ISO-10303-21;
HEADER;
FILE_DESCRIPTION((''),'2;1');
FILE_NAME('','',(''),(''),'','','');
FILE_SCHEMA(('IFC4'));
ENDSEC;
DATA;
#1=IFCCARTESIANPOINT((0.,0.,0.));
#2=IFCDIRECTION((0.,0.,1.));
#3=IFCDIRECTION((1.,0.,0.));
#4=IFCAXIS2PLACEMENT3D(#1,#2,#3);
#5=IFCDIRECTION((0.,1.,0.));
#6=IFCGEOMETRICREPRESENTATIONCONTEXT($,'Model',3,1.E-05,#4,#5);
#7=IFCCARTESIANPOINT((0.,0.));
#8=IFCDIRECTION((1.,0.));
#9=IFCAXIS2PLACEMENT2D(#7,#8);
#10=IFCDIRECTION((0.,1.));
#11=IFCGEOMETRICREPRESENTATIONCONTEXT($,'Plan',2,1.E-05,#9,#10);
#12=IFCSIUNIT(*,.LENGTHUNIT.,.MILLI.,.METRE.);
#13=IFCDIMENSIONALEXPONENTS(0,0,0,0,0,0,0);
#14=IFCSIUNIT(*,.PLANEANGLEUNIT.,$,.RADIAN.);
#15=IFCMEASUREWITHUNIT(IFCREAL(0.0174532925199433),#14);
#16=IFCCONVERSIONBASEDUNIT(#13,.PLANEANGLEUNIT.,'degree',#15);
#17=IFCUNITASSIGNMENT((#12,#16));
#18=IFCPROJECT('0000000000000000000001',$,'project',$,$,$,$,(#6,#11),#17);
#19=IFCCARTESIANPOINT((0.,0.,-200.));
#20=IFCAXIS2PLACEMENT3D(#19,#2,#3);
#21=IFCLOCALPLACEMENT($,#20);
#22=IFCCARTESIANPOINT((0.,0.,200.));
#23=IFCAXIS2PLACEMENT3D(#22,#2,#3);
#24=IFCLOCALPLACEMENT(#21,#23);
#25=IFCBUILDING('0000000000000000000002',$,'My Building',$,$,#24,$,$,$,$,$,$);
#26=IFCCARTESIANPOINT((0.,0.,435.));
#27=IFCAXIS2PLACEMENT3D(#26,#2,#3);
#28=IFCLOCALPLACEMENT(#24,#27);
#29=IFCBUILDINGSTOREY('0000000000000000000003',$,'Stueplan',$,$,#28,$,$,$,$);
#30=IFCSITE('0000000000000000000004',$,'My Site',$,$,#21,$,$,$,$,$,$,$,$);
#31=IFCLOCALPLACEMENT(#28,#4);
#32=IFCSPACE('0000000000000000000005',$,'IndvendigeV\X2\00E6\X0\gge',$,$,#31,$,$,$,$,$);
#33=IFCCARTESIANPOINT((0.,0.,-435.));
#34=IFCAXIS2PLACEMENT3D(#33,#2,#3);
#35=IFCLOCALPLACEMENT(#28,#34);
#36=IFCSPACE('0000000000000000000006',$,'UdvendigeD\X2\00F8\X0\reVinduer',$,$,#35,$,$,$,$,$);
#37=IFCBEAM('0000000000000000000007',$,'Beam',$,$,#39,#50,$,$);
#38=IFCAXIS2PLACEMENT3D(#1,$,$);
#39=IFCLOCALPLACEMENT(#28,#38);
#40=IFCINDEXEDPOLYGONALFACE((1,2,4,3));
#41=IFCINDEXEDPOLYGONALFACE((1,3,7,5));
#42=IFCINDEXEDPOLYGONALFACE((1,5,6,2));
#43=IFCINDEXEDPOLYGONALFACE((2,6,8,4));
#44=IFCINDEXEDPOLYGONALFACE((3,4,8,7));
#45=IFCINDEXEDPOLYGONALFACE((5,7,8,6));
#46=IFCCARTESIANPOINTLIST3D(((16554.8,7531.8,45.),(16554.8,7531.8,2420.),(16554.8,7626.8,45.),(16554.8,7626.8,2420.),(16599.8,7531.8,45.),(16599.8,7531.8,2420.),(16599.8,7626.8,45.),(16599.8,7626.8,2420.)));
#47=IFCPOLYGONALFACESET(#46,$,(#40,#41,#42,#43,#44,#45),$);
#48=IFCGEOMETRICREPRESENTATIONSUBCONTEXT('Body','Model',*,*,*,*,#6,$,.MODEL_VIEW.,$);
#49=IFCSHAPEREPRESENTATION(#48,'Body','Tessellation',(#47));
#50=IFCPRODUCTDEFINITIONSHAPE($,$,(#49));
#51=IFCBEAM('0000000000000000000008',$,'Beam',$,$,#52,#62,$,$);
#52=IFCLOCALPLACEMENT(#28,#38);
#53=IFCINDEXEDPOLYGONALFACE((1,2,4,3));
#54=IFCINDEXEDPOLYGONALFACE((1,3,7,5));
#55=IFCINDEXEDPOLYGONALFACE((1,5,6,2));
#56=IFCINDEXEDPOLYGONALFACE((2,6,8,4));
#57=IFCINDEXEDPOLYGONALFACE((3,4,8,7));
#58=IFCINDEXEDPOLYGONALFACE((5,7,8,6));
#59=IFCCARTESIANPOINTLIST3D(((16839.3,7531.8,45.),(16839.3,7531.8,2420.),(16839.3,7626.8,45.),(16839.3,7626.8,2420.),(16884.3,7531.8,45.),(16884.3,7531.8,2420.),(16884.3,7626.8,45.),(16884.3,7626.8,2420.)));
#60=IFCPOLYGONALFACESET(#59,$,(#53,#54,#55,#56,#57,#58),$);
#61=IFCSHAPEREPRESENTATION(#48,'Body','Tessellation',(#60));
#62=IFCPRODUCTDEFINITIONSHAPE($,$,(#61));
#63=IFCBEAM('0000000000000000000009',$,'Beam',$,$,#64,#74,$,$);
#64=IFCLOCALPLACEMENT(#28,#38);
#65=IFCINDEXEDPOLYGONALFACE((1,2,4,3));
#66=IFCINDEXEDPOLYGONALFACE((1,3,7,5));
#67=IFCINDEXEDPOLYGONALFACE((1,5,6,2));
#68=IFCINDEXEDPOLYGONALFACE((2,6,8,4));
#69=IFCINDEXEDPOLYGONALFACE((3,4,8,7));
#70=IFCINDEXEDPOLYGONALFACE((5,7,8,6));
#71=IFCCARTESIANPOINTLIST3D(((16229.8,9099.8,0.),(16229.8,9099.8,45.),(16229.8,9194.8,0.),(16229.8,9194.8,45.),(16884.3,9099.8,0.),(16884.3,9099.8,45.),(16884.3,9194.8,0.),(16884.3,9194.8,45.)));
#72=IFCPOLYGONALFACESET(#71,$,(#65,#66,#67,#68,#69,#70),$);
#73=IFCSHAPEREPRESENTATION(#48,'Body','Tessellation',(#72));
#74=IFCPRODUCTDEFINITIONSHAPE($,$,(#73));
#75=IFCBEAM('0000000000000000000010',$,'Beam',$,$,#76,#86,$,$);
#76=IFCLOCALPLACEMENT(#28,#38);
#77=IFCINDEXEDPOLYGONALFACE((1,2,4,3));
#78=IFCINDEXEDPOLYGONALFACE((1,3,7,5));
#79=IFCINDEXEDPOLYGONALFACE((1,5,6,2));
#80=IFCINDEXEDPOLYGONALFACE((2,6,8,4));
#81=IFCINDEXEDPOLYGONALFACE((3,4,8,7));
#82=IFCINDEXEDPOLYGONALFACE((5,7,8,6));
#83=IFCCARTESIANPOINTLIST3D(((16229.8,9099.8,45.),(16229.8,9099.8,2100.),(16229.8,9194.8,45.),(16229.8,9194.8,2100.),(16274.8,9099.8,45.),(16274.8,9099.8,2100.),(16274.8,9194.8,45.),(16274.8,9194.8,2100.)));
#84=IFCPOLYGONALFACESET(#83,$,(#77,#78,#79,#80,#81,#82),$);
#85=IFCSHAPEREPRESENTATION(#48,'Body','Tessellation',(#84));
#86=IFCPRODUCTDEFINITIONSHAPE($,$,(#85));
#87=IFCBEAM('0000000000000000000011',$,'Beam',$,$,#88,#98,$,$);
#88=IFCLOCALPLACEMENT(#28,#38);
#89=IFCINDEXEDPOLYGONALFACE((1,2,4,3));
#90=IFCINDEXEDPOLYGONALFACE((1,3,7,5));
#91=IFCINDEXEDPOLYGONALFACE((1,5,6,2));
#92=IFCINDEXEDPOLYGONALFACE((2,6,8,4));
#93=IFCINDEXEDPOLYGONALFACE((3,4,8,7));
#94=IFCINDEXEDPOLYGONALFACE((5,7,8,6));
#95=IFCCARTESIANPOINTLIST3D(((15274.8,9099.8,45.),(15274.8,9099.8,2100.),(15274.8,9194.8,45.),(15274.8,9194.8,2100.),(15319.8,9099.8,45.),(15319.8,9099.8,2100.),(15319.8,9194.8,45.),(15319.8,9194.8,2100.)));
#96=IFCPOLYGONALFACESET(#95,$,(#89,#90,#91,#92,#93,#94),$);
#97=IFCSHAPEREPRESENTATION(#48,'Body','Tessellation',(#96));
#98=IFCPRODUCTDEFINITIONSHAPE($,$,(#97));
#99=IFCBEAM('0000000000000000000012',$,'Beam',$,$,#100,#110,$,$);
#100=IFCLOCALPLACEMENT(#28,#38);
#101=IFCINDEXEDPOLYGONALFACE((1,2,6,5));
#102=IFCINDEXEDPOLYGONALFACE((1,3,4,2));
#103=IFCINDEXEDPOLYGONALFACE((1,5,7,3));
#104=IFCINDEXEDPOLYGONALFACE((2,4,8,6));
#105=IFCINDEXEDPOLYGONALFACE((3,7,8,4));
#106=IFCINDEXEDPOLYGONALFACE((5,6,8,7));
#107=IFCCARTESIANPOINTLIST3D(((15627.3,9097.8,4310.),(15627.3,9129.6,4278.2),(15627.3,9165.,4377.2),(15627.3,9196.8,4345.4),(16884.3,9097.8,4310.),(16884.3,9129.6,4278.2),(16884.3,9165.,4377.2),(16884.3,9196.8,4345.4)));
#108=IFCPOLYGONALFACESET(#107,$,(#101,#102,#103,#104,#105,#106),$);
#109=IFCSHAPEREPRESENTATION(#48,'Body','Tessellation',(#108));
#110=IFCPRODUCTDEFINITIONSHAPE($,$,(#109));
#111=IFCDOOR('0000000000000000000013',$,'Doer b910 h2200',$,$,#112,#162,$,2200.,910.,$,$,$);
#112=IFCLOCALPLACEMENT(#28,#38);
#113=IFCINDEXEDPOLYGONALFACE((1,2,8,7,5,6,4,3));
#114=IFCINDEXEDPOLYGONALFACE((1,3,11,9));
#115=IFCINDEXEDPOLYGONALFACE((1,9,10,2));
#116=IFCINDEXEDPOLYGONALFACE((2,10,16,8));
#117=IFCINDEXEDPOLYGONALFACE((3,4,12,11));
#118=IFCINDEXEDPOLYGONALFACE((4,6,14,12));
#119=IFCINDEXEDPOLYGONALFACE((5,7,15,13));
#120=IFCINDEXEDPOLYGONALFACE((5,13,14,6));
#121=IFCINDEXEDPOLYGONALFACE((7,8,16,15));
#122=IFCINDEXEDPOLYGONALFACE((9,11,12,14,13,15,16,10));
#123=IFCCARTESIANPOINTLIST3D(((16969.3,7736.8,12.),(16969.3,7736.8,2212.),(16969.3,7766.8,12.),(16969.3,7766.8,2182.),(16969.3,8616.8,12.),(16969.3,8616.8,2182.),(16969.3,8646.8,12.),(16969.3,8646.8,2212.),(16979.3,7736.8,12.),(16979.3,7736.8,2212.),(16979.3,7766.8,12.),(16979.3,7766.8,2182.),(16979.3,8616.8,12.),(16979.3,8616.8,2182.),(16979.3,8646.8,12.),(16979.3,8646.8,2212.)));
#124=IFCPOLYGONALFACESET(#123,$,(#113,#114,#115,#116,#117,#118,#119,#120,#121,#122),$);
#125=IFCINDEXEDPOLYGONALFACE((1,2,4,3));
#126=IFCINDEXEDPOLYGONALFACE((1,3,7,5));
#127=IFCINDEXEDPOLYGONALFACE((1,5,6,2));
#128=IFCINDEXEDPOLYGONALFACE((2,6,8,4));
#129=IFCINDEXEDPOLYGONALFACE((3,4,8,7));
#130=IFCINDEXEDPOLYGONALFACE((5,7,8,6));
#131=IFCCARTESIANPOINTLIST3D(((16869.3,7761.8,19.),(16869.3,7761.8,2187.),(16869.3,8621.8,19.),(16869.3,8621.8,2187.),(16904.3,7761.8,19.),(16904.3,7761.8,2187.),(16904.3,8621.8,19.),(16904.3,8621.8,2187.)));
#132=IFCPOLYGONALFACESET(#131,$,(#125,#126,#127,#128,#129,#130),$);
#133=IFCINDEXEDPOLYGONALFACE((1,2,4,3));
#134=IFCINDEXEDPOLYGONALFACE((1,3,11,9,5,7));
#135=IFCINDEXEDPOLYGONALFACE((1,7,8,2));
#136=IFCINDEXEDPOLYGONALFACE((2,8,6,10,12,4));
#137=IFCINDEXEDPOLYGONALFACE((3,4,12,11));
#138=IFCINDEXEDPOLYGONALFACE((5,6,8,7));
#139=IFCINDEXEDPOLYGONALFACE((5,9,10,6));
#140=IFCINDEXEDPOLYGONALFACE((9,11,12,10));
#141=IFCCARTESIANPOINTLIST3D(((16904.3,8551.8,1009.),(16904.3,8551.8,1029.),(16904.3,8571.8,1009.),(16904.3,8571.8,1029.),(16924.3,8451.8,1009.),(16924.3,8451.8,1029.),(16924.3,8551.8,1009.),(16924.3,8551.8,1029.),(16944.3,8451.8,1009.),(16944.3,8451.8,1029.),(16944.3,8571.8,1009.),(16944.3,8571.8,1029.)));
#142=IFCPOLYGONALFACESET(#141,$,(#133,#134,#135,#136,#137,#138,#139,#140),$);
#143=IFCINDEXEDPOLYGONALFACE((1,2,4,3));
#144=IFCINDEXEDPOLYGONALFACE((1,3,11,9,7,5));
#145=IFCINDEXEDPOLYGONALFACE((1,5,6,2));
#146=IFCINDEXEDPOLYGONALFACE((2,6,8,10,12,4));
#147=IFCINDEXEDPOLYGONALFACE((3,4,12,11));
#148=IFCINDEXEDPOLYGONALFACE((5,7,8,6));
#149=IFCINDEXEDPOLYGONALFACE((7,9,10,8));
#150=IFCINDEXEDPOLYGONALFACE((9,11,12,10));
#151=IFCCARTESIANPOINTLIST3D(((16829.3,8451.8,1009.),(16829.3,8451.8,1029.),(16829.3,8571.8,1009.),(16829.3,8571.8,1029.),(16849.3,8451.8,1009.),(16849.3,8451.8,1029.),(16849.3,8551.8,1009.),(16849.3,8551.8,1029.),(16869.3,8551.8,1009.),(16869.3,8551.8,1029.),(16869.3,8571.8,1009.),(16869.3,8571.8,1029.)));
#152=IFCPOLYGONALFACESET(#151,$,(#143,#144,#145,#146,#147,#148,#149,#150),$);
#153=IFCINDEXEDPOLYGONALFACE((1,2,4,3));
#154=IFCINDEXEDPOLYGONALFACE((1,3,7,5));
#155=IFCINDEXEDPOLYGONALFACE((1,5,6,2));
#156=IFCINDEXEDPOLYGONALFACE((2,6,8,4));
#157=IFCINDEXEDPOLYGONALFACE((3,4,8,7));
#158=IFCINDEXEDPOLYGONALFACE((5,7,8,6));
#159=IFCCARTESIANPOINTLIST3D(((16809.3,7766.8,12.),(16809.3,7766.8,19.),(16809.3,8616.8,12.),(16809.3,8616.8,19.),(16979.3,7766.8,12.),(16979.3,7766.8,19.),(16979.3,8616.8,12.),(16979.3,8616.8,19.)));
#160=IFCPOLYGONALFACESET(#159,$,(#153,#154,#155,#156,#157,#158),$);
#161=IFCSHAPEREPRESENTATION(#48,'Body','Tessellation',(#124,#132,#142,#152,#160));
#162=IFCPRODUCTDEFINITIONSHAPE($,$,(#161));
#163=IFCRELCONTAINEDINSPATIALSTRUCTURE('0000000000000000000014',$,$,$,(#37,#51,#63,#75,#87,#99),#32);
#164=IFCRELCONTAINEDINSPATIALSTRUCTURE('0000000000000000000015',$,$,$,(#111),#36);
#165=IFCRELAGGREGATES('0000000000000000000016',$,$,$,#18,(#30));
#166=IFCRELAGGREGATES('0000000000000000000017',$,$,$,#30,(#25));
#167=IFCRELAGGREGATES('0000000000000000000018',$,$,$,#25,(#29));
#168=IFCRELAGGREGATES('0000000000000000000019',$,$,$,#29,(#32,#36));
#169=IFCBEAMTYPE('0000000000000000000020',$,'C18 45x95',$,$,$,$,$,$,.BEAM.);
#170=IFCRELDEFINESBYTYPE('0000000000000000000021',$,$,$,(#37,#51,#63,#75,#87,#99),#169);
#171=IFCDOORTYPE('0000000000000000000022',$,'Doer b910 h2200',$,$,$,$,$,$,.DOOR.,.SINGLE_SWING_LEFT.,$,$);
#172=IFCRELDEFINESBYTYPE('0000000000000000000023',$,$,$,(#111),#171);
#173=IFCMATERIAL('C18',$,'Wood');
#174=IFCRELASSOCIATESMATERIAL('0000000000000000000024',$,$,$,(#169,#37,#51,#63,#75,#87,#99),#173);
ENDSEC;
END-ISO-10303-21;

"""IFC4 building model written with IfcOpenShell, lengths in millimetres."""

from ifc_helpers import new_model, entity, si_unit, converted_unit, direction, frame, origin_with_axes, origin_2d_with_axis, place, context, subcontext, project, spatial, line, indexed_curve, rectangle, outline, extrude, shape, source, transform, mapped, material, material_profile, profile_set, profile_usage, type_object, type_shapes, element, save


model = new_model("IFC4")

# Units and contexts
model_context = context("Model", 3, precision=1e-05, world=origin_with_axes(), true_north=direction((0.0, 1.0, 0.0)))
plan_context = context("Plan", 2, precision=1e-05, world=origin_2d_with_axis(), true_north=direction((0.0, 1.0)))
body_context_1 = subcontext(model_context, "Body", "Model", "MODEL_VIEW")
body_context_2 = subcontext(plan_context, "Body", "Plan", "PLAN_VIEW")
ifc_project = project(units=[si_unit("LENGTHUNIT", "METRE", prefix="MILLI"), converted_unit("PLANEANGLEUNIT", "degree", entity("IfcReal", 0.0174532925199433), si_unit("PLANEANGLEUNIT", "RADIAN"), dimensions=[0, 0, 0, 0, 0, 0, 0])], contexts=[model_context, plan_context])

# Site, building, storey
site_placement = place(None, frame((0.0, 0.0, -200.0), z_axis=(0.0, 0.0, 1.0), x_axis=(1.0, 0.0, 0.0)))
site = spatial("IfcSite", under=ifc_project, at=site_placement, Name="My Site")
building_placement = place(site_placement, frame((0.0, 0.0, 200.0), z_axis=(0.0, 0.0, 1.0), x_axis=(1.0, 0.0, 0.0)))
building = spatial("IfcBuilding", under=site, at=building_placement, Name="My Building")
storey_placement = place(building_placement, frame((0.0, 0.0, 435.0), z_axis=(0.0, 0.0, 1.0), x_axis=(1.0, 0.0, 0.0)))
storey = spatial("IfcBuildingStorey", under=building, at=storey_placement, Name="Stueplan")

# Shared definitions
ifc_material = material(Name="C18", Category="Wood")

# Shared definitions
space_1_placement = place(storey_placement, frame((0.0, 0.0, 0.0), z_axis=(0.0, 0.0, 1.0), x_axis=(1.0, 0.0, 0.0)))
space_1 = spatial("IfcSpace", under=storey, at=space_1_placement, Name="IndvendigeVægge")

# Beams
ifc_material_profile_1 = material_profile(ifc_material, rectangle(XDim=45.0, YDim=95.0))
ifc_profile_set_1 = profile_set([ifc_material_profile_1], Name="woodStructural")
beam_type_1 = type_object("IfcBeamType", Name="C18 45x95", PredefinedType="BEAM", material=ifc_profile_set_1)
ifc_profile_usage_1 = profile_usage(ifc_profile_set_1)
beam_1_placement = place(space_1_placement, frame((16577.3, 7579.3, 45.0), z_axis=(0.0, 0.0, 1.0), x_axis=(1.0, 0.0, 0.0)))
element("IfcBeam", 1, at=beam_1_placement, inside=space_1, type_object=beam_type_1, material=ifc_profile_usage_1, Name="Beam", context=body_context_1, shape_type="SweptSolid", body=[
    extrude(rectangle(XDim=45.0, YDim=95.0), origin_with_axes(), (0.0, 0.0, 1.0), 2375.0),
])
ifc_profile_usage_2 = profile_usage(ifc_profile_set_1)
beam_2_placement = place(space_1_placement, frame((16861.8, 7579.3, 45.0), z_axis=(0.0, 0.0, 1.0), x_axis=(1.0, 0.0, 0.0)))
element("IfcBeam", 2, at=beam_2_placement, inside=space_1, type_object=beam_type_1, material=ifc_profile_usage_2, Name="Beam", context=body_context_1, shape_type="SweptSolid", body=[
    extrude(rectangle(XDim=45.0, YDim=95.0), origin_with_axes(), (0.0, 0.0, 1.0), 2375.0),
])
ifc_profile_usage_3 = profile_usage(ifc_profile_set_1, cardinal=5)
beam_3_placement = place(space_1_placement, frame((16229.8, 9147.3, 22.5), z_axis=(1.0, 0.0, 0.0), x_axis=(0.0, 0.0, 1.0)))
element("IfcBeam", 3, at=beam_3_placement, inside=space_1, type_object=beam_type_1, material=ifc_profile_usage_3, Name="Beam", context=body_context_1, shape_type="SweptSolid", body=[
    extrude(rectangle(XDim=45.0, YDim=95.0), origin_with_axes(), (0.0, 0.0, 1.0), 654.5),
])
ifc_profile_usage_4 = profile_usage(ifc_profile_set_1)
beam_4_placement = place(space_1_placement, frame((16252.3, 9147.3, 45.0), z_axis=(0.0, 0.0, 1.0), x_axis=(1.0, 0.0, 0.0)))
element("IfcBeam", 4, at=beam_4_placement, inside=space_1, type_object=beam_type_1, material=ifc_profile_usage_4, Name="Beam", context=body_context_1, shape_type="SweptSolid", body=[
    extrude(rectangle(XDim=45.0, YDim=95.0), origin_with_axes(), (0.0, 0.0, 1.0), 2055.0),
])
ifc_profile_usage_5 = profile_usage(ifc_profile_set_1)
beam_5_placement = place(space_1_placement, frame((15297.3, 9147.3, 45.0), z_axis=(0.0, 0.0, 1.0), x_axis=(1.0, 0.0, 0.0)))
element("IfcBeam", 5, at=beam_5_placement, inside=space_1, type_object=beam_type_1, material=ifc_profile_usage_5, Name="Beam", context=body_context_1, shape_type="SweptSolid", body=[
    extrude(rectangle(XDim=45.0, YDim=95.0), origin_with_axes(), (0.0, 0.0, 1.0), 2055.0),
])
ifc_profile_usage_6 = profile_usage(ifc_profile_set_1, cardinal=5)
beam_6_placement = place(space_1_placement, frame((15627.3, 9147.3, 4327.7), z_axis=(1.0, -0.000001, 0.0), x_axis=(0.0, -0.707107, 0.707107)))
element("IfcBeam", 6, at=beam_6_placement, inside=space_1, type_object=beam_type_1, material=ifc_profile_usage_6, Name="Beam", context=body_context_1, shape_type="SweptSolid", body=[
    extrude(rectangle(XDim=45.0, YDim=95.0), origin_with_axes(), (0.0, 0.0, 1.0), 1257.0),
])

# Shared definitions
space_2_placement = place(storey_placement, frame((0.0, 0.0, -435.0), z_axis=(0.0, 0.0, 1.0), x_axis=(1.0, 0.0, 0.0)))
space_2 = spatial("IfcSpace", under=storey, at=space_2_placement, Name="UdvendigeDøreVinduer")

# Door
door_type_1 = type_object("IfcDoorType", Name="Doer b910 h2200", OperationType="SINGLE_SWING_LEFT", PredefinedType="DOOR")
shared_shape_1 = source(origin_with_axes(), body_context_1, "Body", "SweptSolid", [
    extrude(outline(indexed_curve([(0.0, 0.0), (0.0, 2200.0), (910.0, 2200.0), (910.0, 0.0), (880.0, 0.0), (880.0, 2170.0), (30.0, 2170.0), (30.0, 0.0)], segments=[line(1, 2, 3, 4, 5, 6, 7, 8, 1)])), frame((0.0, 0.0, 0.0), z_axis=(0.0, -1.0, 0.0), x_axis=(1.0, 0.0, 0.0)), (0.0, 0.0, -1.0), 10.0),
    extrude(outline(indexed_curve([(0.0, 0.0), (860.0, 0.0), (860.0, 35.0), (0.0, 35.0)], segments=[line(1, 2, 3, 4, 1)])), frame((25.0, 75.0, 7.0), z_axis=(0.0, 0.0, 1.0), x_axis=(1.0, 0.0, 0.0)), (0.0, 0.0, 1.0), 2168.0),
    extrude(outline(indexed_curve([(0.0, 0.0), (0.0, -40.0), (-120.0, -40.0), (-120.0, -20.0), (-20.0, -20.0), (-20.0, 0.0)], segments=[line(1, 2, 3, 4, 5, 6, 1)])), frame((835.0, 75.0, 997.0), z_axis=(0.0, 0.0, 1.0), x_axis=(1.0, 0.0, 0.0)), (0.0, 0.0, 1.0), 20.0),
    extrude(outline(indexed_curve([(0.0, 0.0), (0.0, 40.0), (-120.0, 40.0), (-120.0, 20.0), (-20.0, 20.0), (-20.0, 0.0)], segments=[line(1, 2, 3, 4, 5, 6, 1)])), frame((835.0, 110.0, 997.0), z_axis=(0.0, 0.0, 1.0), x_axis=(1.0, 0.0, 0.0)), (0.0, 0.0, 1.0), 20.0),
    extrude(outline(indexed_curve([(0.0, 0.0), (850.0, 0.0), (850.0, 170.0), (0.0, 170.0)], segments=[line(1, 2, 3, 4, 1)])), frame((30.0, 0.0, 0.0), z_axis=(0.0, 0.0, 1.0), x_axis=(1.0, 0.0, 0.0)), (0.0, 0.0, 1.0), 7.0),
])
shared_shape_2 = source(origin_with_axes(), body_context_2, "Body", "Curve2D", [
    entity("IfcIndexedPolyCurve", entity("IfcCartesianPointList2D", [[0.0, 0.0], [30.0, 0.0], [30.0, 10.0], [0.0, 10.0]]), [entity("IfcLineIndex", [1, 2, 3, 4, 1])]),
    entity("IfcIndexedPolyCurve", entity("IfcCartesianPointList2D", [[910.0, 0.0], [880.0, 0.0], [880.0, 10.0], [910.0, 10.0]]), [entity("IfcLineIndex", [1, 2, 3, 4, 1])]),
    entity("IfcTrimmedCurve", entity("IfcEllipse", entity("IfcAxis2Placement2D", entity("IfcCartesianPoint", [60.0, 10.0]), entity("IfcDirection", [1.0, 0.0])), 825.0, 860.0), [entity("IfcCartesianPoint", [885.0, 10.0])], [entity("IfcCartesianPoint", [60.0, 870.0])], True, "CARTESIAN"),
    entity("IfcIndexedPolyCurve", entity("IfcCartesianPointList2D", [[25.0, 10.0], [60.0, 10.0], [60.0, 870.0], [25.0, 870.0]]), [entity("IfcLineIndex", [1, 2, 3, 4, 1])]),
])
type_shapes(door_type_1, [shared_shape_1, shared_shape_2])
door_1_placement = place(space_2_placement, frame((16979.3, 7736.8, 447.0), z_axis=(0.0, 0.0, 1.0), x_axis=(0.0, 1.0, 0.0)))
element("IfcDoor", 7, at=door_1_placement, inside=space_2, type_object=door_type_1, Name="Doer b910 h2200", OverallHeight=2200.0, OverallWidth=910.0, shapes=[
    shape(body_context_1, "Body", "MappedRepresentation", [mapped(shared_shape_1, transform((0.0, 0.0, 0.0), x_axis=(1.0, 0.0, 0.0), y_axis=(0.0, 1.0, 0.0), z_axis=(0.0, 0.0, 1.0), scale=1.0))]),
    shape(body_context_2, "Body", "MappedRepresentation", [mapped(shared_shape_2, transform((0.0, 0.0, 0.0), x_axis=(1.0, 0.0, 0.0), y_axis=(0.0, 1.0, 0.0), z_axis=(0.0, 0.0, 1.0), scale=1.0))]),
])

save(model, "model.ifc")
